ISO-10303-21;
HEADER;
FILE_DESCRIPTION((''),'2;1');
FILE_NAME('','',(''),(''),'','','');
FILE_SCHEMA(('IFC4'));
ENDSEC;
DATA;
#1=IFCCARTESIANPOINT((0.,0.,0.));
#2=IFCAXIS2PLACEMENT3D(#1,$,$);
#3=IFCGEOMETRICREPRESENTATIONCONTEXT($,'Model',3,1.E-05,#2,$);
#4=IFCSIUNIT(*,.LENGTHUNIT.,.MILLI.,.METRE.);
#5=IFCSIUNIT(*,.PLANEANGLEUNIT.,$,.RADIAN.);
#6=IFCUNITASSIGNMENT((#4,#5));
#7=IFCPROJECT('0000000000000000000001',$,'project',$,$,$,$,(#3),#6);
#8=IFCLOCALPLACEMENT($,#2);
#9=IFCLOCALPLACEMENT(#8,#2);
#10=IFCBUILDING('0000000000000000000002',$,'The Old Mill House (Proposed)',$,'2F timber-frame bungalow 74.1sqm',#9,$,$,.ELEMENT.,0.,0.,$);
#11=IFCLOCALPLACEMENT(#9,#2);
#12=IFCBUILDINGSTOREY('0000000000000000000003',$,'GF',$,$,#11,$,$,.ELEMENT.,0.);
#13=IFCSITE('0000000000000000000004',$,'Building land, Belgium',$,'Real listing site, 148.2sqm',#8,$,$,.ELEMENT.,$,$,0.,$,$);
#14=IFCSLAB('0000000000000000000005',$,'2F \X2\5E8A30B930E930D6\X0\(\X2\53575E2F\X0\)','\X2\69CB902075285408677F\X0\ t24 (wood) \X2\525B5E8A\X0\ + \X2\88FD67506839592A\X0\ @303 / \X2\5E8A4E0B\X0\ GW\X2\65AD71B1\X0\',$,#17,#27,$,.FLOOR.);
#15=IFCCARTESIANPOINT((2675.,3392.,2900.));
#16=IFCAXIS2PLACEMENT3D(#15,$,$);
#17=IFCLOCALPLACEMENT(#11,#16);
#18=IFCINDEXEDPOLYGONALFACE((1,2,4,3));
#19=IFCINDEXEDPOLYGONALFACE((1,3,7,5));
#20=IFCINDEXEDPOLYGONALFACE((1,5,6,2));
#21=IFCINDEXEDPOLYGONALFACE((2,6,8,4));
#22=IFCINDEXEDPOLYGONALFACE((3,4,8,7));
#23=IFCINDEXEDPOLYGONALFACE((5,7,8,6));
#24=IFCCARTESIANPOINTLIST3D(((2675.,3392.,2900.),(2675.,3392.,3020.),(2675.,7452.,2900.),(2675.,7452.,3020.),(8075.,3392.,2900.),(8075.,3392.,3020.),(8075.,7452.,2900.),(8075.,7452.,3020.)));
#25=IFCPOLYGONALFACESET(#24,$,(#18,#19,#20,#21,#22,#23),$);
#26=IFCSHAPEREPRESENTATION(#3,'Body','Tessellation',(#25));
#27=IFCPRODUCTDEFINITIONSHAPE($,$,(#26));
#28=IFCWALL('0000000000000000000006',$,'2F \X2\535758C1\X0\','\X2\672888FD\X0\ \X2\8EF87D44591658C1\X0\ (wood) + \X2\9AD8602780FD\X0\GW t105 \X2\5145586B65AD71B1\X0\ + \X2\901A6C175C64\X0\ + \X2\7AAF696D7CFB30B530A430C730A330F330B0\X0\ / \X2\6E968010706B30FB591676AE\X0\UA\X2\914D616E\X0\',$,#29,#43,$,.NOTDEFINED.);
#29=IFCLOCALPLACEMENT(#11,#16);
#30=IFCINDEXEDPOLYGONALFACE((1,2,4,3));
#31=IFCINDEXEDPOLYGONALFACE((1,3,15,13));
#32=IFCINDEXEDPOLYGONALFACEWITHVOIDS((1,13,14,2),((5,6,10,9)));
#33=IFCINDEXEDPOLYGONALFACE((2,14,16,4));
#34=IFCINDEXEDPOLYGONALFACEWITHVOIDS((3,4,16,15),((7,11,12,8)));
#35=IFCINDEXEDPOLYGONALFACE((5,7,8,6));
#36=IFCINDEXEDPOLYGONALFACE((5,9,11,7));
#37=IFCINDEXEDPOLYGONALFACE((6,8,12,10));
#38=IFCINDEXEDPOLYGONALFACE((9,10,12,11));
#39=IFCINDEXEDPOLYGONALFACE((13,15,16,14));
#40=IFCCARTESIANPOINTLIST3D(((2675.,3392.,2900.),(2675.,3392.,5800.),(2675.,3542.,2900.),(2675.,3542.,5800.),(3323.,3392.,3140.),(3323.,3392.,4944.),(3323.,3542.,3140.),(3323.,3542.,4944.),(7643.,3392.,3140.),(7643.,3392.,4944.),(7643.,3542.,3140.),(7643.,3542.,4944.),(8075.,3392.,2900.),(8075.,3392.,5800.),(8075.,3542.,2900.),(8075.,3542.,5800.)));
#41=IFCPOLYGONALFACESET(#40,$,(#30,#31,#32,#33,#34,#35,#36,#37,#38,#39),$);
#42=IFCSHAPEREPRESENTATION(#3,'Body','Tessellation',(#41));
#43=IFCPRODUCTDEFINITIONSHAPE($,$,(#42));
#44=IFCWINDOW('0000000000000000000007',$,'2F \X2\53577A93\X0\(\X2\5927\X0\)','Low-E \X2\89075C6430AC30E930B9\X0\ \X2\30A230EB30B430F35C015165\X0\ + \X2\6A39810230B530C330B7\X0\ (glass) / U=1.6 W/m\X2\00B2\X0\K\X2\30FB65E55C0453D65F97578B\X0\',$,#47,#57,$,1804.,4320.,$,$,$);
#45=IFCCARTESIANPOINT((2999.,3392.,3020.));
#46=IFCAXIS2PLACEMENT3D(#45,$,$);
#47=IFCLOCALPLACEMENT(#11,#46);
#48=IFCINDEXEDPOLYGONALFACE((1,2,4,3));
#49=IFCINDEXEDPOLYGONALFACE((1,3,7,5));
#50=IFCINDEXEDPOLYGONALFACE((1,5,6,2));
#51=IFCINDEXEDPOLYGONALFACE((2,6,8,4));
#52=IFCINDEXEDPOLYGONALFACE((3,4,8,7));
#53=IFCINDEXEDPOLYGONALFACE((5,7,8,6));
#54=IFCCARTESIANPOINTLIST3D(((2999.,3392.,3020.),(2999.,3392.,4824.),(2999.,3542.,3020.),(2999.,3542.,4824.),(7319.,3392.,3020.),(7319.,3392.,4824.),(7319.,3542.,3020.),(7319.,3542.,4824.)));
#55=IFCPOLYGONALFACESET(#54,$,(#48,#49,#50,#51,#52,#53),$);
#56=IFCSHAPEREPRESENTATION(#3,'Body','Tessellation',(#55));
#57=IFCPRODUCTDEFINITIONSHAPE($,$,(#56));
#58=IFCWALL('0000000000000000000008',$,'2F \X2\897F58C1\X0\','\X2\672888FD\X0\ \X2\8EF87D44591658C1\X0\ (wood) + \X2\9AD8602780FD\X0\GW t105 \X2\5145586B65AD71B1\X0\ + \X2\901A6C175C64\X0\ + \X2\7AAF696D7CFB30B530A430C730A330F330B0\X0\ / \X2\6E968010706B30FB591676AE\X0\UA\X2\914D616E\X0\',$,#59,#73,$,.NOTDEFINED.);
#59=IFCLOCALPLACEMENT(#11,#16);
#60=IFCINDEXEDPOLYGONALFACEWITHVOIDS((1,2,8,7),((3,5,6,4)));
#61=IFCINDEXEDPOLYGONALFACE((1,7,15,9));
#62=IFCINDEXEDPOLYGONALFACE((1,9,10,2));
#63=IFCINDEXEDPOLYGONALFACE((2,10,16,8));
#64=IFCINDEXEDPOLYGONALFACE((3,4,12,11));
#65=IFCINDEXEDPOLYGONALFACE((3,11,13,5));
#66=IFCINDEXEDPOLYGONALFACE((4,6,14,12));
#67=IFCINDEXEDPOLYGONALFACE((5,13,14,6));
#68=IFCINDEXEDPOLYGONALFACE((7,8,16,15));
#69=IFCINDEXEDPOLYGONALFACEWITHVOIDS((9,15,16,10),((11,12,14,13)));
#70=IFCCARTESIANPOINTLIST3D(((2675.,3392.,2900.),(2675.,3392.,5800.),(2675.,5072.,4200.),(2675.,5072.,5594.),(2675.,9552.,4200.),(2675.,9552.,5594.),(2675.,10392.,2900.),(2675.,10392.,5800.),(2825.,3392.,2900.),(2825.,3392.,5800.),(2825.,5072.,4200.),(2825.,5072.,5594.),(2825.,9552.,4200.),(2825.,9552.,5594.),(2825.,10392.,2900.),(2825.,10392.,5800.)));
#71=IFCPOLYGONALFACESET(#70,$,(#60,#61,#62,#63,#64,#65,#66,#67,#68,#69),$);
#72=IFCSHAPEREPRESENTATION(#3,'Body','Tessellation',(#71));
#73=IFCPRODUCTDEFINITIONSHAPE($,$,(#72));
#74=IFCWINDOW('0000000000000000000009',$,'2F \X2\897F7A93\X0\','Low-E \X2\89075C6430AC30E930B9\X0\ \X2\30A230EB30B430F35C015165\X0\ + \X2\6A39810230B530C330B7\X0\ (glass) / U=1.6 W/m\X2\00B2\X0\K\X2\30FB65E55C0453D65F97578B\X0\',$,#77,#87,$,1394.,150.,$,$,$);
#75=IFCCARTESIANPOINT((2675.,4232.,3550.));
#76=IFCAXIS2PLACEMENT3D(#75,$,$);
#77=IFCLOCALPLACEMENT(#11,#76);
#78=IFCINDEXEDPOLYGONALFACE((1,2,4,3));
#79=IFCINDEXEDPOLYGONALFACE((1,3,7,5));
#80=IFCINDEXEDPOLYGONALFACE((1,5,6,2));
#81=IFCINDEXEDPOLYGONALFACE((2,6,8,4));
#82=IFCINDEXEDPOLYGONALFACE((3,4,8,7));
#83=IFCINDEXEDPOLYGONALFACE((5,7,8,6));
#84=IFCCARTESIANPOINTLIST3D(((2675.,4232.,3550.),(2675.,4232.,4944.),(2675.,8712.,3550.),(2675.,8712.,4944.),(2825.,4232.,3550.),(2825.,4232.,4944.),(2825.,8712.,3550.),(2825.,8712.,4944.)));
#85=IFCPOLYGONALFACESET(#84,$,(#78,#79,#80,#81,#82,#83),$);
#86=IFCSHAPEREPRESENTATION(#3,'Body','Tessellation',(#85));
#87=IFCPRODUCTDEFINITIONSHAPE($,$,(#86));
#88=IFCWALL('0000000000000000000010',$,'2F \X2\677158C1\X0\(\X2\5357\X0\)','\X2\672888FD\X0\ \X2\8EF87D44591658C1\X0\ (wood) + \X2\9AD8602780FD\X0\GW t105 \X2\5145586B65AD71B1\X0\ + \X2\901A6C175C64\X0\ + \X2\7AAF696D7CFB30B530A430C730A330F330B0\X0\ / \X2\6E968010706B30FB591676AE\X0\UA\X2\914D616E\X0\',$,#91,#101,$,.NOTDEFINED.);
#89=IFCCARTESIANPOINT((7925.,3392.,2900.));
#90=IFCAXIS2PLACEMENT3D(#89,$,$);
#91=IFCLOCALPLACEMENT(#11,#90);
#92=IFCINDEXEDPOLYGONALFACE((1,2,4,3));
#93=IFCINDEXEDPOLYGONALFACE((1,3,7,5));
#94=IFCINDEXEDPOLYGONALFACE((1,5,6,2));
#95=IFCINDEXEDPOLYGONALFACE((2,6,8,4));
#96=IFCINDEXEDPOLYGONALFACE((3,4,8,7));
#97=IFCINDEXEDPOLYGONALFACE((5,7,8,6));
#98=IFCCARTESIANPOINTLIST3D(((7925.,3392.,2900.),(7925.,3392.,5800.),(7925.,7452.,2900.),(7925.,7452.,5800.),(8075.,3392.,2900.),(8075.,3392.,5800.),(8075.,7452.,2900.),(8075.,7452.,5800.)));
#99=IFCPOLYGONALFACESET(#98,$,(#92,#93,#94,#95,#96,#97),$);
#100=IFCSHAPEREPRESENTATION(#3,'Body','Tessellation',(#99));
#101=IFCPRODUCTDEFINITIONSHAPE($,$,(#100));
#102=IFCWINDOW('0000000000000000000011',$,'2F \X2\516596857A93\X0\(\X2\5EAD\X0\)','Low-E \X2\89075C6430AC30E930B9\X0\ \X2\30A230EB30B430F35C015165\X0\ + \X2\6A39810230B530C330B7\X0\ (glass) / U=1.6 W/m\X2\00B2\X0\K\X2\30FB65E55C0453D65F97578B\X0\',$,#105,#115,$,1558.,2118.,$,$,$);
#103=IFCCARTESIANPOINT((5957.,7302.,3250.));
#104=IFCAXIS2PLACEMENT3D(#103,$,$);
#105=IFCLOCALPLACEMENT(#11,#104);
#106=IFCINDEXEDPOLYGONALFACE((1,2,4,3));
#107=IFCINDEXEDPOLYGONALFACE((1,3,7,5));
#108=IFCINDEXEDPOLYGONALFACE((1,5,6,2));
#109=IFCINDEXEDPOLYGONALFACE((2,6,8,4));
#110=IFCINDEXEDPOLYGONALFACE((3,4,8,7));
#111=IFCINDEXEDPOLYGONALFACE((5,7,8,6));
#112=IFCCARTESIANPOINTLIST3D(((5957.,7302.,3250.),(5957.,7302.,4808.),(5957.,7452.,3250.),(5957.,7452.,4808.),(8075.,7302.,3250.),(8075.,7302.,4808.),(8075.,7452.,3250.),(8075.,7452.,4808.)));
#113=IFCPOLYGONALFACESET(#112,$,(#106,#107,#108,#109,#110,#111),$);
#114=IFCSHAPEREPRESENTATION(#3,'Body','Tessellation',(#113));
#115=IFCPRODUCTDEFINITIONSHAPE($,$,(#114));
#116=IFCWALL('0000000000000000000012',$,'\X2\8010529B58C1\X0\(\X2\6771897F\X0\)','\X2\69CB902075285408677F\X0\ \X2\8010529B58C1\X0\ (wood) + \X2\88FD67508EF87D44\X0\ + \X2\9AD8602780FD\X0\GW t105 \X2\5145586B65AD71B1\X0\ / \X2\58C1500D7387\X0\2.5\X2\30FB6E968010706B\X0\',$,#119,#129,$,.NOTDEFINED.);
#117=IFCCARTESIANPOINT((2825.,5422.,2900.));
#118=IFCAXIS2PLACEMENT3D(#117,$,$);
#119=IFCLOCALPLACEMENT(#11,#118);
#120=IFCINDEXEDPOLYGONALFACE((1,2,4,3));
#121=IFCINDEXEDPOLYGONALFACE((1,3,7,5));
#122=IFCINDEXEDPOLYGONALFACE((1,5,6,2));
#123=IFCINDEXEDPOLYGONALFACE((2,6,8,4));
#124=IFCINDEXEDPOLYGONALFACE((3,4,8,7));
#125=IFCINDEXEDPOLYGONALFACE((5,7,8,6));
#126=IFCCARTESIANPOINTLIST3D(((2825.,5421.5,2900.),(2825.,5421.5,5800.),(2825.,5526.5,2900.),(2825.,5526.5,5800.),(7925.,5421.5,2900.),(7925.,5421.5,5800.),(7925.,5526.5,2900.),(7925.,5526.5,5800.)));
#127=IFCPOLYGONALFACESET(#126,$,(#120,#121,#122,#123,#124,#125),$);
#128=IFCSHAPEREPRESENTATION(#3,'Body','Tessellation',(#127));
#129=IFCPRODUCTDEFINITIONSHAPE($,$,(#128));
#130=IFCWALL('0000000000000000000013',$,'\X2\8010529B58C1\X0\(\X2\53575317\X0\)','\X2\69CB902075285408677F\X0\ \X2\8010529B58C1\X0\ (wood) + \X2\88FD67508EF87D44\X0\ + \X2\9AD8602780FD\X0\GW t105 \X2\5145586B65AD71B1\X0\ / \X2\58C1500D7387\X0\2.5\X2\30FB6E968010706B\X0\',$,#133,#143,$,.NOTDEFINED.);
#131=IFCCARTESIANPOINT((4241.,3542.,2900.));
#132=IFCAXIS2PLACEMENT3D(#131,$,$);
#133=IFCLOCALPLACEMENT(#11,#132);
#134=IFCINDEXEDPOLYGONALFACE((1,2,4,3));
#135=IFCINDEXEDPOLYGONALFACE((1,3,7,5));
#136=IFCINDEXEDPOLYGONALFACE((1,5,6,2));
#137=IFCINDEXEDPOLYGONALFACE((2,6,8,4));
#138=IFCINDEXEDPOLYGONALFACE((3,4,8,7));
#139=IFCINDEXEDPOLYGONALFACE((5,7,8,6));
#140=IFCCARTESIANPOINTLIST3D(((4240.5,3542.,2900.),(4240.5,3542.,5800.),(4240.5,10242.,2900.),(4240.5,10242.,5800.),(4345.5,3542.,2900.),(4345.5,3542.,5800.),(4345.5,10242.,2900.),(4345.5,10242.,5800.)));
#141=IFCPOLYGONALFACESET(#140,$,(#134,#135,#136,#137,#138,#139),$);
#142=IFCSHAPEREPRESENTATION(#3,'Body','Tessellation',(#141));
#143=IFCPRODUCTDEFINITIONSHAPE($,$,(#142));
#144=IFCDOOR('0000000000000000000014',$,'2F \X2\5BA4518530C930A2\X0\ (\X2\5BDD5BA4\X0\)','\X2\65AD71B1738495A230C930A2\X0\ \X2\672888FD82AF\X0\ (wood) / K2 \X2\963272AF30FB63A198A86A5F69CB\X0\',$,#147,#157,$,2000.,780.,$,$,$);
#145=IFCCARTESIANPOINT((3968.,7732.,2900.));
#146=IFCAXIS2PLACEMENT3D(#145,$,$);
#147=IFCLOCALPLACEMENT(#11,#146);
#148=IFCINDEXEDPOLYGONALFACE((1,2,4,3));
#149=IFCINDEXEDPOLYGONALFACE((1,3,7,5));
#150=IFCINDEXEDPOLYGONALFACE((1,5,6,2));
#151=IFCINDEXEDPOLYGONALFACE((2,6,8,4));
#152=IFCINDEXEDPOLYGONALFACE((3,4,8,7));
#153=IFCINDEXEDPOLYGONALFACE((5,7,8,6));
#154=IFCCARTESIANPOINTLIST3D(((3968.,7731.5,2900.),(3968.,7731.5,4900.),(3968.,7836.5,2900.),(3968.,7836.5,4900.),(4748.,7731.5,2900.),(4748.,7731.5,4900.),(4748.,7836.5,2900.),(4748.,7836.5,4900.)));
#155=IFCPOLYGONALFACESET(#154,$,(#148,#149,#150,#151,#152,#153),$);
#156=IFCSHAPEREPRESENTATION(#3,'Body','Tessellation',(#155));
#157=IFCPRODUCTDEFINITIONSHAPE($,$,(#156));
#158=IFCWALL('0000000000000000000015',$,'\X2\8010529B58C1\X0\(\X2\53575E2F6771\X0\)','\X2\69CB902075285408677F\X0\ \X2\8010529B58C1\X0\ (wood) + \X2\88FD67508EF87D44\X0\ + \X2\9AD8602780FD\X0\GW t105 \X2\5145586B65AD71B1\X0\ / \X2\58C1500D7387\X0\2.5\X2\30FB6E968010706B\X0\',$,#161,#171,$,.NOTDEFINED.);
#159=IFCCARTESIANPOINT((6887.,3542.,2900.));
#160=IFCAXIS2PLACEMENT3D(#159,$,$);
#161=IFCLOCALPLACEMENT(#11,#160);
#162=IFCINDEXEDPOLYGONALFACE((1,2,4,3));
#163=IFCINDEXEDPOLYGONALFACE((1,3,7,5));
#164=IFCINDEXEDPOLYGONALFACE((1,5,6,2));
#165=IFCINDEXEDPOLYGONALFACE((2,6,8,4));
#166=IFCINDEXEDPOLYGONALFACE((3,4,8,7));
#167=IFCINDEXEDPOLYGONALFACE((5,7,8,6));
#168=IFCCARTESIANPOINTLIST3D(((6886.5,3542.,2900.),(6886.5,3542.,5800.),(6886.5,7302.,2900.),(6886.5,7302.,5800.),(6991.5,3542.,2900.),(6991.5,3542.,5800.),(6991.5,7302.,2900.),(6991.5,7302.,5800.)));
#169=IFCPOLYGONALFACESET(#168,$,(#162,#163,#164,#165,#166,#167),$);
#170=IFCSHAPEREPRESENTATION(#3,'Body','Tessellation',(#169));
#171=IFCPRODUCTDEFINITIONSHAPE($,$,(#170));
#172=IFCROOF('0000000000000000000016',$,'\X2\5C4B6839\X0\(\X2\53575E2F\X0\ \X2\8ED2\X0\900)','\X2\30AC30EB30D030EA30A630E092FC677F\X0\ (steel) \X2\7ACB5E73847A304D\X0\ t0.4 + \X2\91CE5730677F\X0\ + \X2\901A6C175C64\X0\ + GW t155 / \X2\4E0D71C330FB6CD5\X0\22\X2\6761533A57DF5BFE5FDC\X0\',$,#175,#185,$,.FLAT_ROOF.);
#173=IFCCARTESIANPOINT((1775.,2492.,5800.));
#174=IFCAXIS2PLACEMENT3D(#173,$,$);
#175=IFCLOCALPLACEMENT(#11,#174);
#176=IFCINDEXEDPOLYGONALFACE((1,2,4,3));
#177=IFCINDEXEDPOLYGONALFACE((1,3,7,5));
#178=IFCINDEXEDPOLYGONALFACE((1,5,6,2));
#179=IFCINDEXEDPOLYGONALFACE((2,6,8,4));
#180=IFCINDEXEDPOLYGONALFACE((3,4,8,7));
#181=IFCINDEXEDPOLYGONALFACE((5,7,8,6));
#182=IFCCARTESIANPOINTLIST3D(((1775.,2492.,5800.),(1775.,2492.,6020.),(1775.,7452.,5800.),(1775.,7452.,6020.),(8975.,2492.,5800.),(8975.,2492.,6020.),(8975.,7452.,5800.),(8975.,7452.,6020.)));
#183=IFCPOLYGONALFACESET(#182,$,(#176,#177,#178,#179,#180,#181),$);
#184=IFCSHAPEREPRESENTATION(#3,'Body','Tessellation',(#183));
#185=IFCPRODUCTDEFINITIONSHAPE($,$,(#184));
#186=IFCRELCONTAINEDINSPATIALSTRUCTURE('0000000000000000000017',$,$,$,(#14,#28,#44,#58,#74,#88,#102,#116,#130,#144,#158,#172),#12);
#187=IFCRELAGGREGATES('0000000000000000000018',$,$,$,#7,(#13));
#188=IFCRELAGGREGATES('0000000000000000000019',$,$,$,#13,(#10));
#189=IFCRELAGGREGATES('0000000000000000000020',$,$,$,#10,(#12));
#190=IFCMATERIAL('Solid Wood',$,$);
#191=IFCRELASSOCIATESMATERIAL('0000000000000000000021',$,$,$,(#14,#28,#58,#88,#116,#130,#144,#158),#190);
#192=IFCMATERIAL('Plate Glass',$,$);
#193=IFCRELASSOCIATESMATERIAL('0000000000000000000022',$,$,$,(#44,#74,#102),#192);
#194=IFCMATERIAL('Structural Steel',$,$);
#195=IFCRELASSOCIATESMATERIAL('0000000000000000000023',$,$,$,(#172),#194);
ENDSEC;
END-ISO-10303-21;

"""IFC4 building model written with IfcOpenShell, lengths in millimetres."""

from ifc_helpers import new_model, si_unit, frame, frame_2d, origin, place, context, project, spatial, rectangle, extrude, material, element, fill, save


model = new_model("IFC4")

# Units and contexts
model_context = context("Model", 3, precision=1e-05, world=origin())
ifc_project = project(units=[si_unit("LENGTHUNIT", "METRE", prefix="MILLI"), si_unit("PLANEANGLEUNIT", "RADIAN")], contexts=[model_context])

# Site, building, storey
site_placement = place(None, origin())
site = spatial("IfcSite", under=ifc_project, at=site_placement, Name="Building land, Belgium", ObjectType="Real listing site, 148.2sqm", CompositionType="ELEMENT", RefElevation=0.0)
building_placement = place(site_placement, origin())
building = spatial("IfcBuilding", under=site, at=building_placement, Name="The Old Mill House (Proposed)", ObjectType="2F timber-frame bungalow 74.1sqm", CompositionType="ELEMENT", ElevationOfRefHeight=0.0, ElevationOfTerrain=0.0)
storey_placement = place(building_placement, origin())
storey = spatial("IfcBuildingStorey", under=building, at=storey_placement, Name="GF", CompositionType="ELEMENT", Elevation=0.0)

# Slab
ifc_material_1 = material(Name="Solid Wood")
slab_placement = place(storey_placement, frame((2675.0, 3392.0, 2900.0)))
element("IfcSlab", 1, at=slab_placement, inside=storey, material=ifc_material_1, Name="2F 床スラブ(南帯)", Description="構造用合板 t24 (wood) 剛床 + 製材根太 @303 / 床下 GW断熱", PredefinedType="FLOOR", context=model_context, shape_type="SweptSolid", body=[
    extrude(rectangle(XDim=5400.0, YDim=4060.0, at=frame_2d((2700.0, 2030.0))), frame((2675.0, 3392.0, 2900.0)), (0.0, 0.0, 1.0), 120.0),
])

# Walls, openings, windows
wall_1_placement = place(storey_placement, frame((2675.0, 3392.0, 2900.0)))
wall_1 = element("IfcWall", 2, at=wall_1_placement, inside=storey, material=ifc_material_1, Name="2F 南壁", Description="木製 軸組外壁 (wood) + 高性能GW t105 充填断熱 + 通気層 + 窯業系サイディング / 準耐火・外皮UA配慮", PredefinedType="NOTDEFINED", context=model_context, shape_type="SweptSolid", body=[
    extrude(rectangle(XDim=5400.0, YDim=150.0, at=frame_2d((2700.0, 75.0))), frame((2675.0, 3392.0, 2900.0)), (0.0, 0.0, 1.0), 2900.0),
])
opening_1_placement = place(storey_placement, frame((2999.0, 3392.0, 3020.0)))
opening_1 = element("IfcOpeningElement", 3, at=opening_1_placement, cuts=wall_1, PredefinedType="NOTDEFINED", context=model_context, shape_type="SweptSolid", body=[
    extrude(rectangle(XDim=4320.0, YDim=150.0, at=frame_2d((2160.0, 75.0))), frame((2999.0, 3392.0, 3020.0)), (0.0, 0.0, 1.0), 1804.0),
])
ifc_material_2 = material(Name="Plate Glass")
window_1_placement = place(storey_placement, frame((2999.0, 3392.0, 3020.0)))
window_1 = element("IfcWindow", 4, at=window_1_placement, inside=storey, material=ifc_material_2, Name="2F 南窓(大)", Description="Low-E 複層ガラス アルゴン封入 + 樹脂サッシ (glass) / U=1.6 W/m²K・日射取得型", OverallHeight=1804.0, OverallWidth=4320.0, context=model_context, shape_type="SweptSolid", body=[
    extrude(rectangle(XDim=4320.0, YDim=150.0, at=frame_2d((2160.0, 75.0))), frame((2999.0, 3392.0, 3020.0)), (0.0, 0.0, 1.0), 1804.0),
])
fill(opening_1, window_1)
wall_2_placement = place(storey_placement, frame((2675.0, 3392.0, 2900.0)))
wall_2 = element("IfcWall", 5, at=wall_2_placement, inside=storey, material=ifc_material_1, Name="2F 西壁", Description="木製 軸組外壁 (wood) + 高性能GW t105 充填断熱 + 通気層 + 窯業系サイディング / 準耐火・外皮UA配慮", PredefinedType="NOTDEFINED", context=model_context, shape_type="SweptSolid", body=[
    extrude(rectangle(XDim=150.0, YDim=7000.0, at=frame_2d((75.0, 3500.0))), frame((2675.0, 3392.0, 2900.0)), (0.0, 0.0, 1.0), 2900.0),
])
opening_2_placement = place(storey_placement, frame((2675.0, 4232.0, 3550.0)))
opening_2 = element("IfcOpeningElement", 6, at=opening_2_placement, cuts=wall_2, PredefinedType="NOTDEFINED", context=model_context, shape_type="SweptSolid", body=[
    extrude(rectangle(XDim=150.0, YDim=4480.0, at=frame_2d((75.0, 2240.0))), frame((2675.0, 4232.0, 3550.0)), (0.0, 0.0, 1.0), 1394.0),
])
window_2_placement = place(storey_placement, frame((2675.0, 4232.0, 3550.0)))
window_2 = element("IfcWindow", 7, at=window_2_placement, inside=storey, material=ifc_material_2, Name="2F 西窓", Description="Low-E 複層ガラス アルゴン封入 + 樹脂サッシ (glass) / U=1.6 W/m²K・日射取得型", OverallHeight=1394.0, OverallWidth=150.0, context=model_context, shape_type="SweptSolid", body=[
    extrude(rectangle(XDim=150.0, YDim=4480.0, at=frame_2d((75.0, 2240.0))), frame((2675.0, 4232.0, 3550.0)), (0.0, 0.0, 1.0), 1394.0),
])
fill(opening_2, window_2)
wall_3_placement = place(storey_placement, frame((7925.0, 3392.0, 2900.0)))
wall_3 = element("IfcWall", 8, at=wall_3_placement, inside=storey, material=ifc_material_1, Name="2F 東壁(南)", Description="木製 軸組外壁 (wood) + 高性能GW t105 充填断熱 + 通気層 + 窯業系サイディング / 準耐火・外皮UA配慮", PredefinedType="NOTDEFINED", context=model_context, shape_type="SweptSolid", body=[
    extrude(rectangle(XDim=150.0, YDim=4060.0, at=frame_2d((75.0, 2030.0))), frame((7925.0, 3392.0, 2900.0)), (0.0, 0.0, 1.0), 2900.0),
])
opening_3_placement = place(storey_placement, frame((5957.0, 7302.0, 3250.0)))
opening_3 = element("IfcOpeningElement", 9, at=opening_3_placement, cuts=wall_3, PredefinedType="NOTDEFINED", context=model_context, shape_type="SweptSolid", body=[
    extrude(rectangle(XDim=2118.0, YDim=150.0, at=frame_2d((1059.0, 75.0))), frame((5957.0, 7302.0, 3250.0)), (0.0, 0.0, 1.0), 1558.0),
])
window_3_placement = place(storey_placement, frame((5957.0, 7302.0, 3250.0)))
window_3 = element("IfcWindow", 10, at=window_3_placement, inside=storey, material=ifc_material_2, Name="2F 入隅窓(庭)", Description="Low-E 複層ガラス アルゴン封入 + 樹脂サッシ (glass) / U=1.6 W/m²K・日射取得型", OverallHeight=1558.0, OverallWidth=2118.0, context=model_context, shape_type="SweptSolid", body=[
    extrude(rectangle(XDim=2118.0, YDim=150.0, at=frame_2d((1059.0, 75.0))), frame((5957.0, 7302.0, 3250.0)), (0.0, 0.0, 1.0), 1558.0),
])
fill(opening_3, window_3)

# Wall
wall_4_placement = place(storey_placement, frame((2825.0, 5422.0, 2900.0)))
element("IfcWall", 11, at=wall_4_placement, inside=storey, material=ifc_material_1, Name="耐力壁(東西)", Description="構造用合板 耐力壁 (wood) + 製材軸組 + 高性能GW t105 充填断熱 / 壁倍率2.5・準耐火", PredefinedType="NOTDEFINED", context=model_context, shape_type="SweptSolid", body=[
    extrude(rectangle(XDim=5100.0, YDim=105.0, at=frame_2d((2550.0, 52.0))), frame((2825.0, 5422.0, 2900.0)), (0.0, 0.0, 1.0), 2900.0),
])

# Wall, opening, door
wall_5_placement = place(storey_placement, frame((4241.0, 3542.0, 2900.0)))
wall_5 = element("IfcWall", 12, at=wall_5_placement, inside=storey, material=ifc_material_1, Name="耐力壁(南北)", Description="構造用合板 耐力壁 (wood) + 製材軸組 + 高性能GW t105 充填断熱 / 壁倍率2.5・準耐火", PredefinedType="NOTDEFINED", context=model_context, shape_type="SweptSolid", body=[
    extrude(rectangle(XDim=105.0, YDim=6700.0, at=frame_2d((52.0, 3350.0))), frame((4241.0, 3542.0, 2900.0)), (0.0, 0.0, 1.0), 2900.0),
])
opening_4_placement = place(storey_placement, frame((3968.0, 7732.0, 2900.0)))
opening_4 = element("IfcOpeningElement", 13, at=opening_4_placement, cuts=wall_5, PredefinedType="NOTDEFINED", context=model_context, shape_type="SweptSolid", body=[
    extrude(rectangle(XDim=780.0, YDim=105.0, at=frame_2d((390.0, 52.0))), frame((3968.0, 7732.0, 2900.0)), (0.0, 0.0, 1.0), 2000.0),
])
door_placement = place(storey_placement, frame((3968.0, 7732.0, 2900.0)))
door = element("IfcDoor", 14, at=door_placement, inside=storey, material=ifc_material_1, Name="2F 室内ドア (寝室)", Description="断熱玄関ドア 木製芯 (wood) / K2 防犯・採風機構", OverallHeight=2000.0, OverallWidth=780.0, context=model_context, shape_type="SweptSolid", body=[
    extrude(rectangle(XDim=780.0, YDim=105.0, at=frame_2d((390.0, 52.0))), frame((3968.0, 7732.0, 2900.0)), (0.0, 0.0, 1.0), 2000.0),
])
fill(opening_4, door)

# Wall
wall_6_placement = place(storey_placement, frame((6887.0, 3542.0, 2900.0)))
element("IfcWall", 15, at=wall_6_placement, inside=storey, material=ifc_material_1, Name="耐力壁(南帯東)", Description="構造用合板 耐力壁 (wood) + 製材軸組 + 高性能GW t105 充填断熱 / 壁倍率2.5・準耐火", PredefinedType="NOTDEFINED", context=model_context, shape_type="SweptSolid", body=[
    extrude(rectangle(XDim=105.0, YDim=3760.0, at=frame_2d((52.0, 1880.0))), frame((6887.0, 3542.0, 2900.0)), (0.0, 0.0, 1.0), 2900.0),
])

# Roof
ifc_material_3 = material(Name="Structural Steel")
for number, where, name in (
    (16, (1775.0, 2492.0, 5800.0), "屋根(南帯 軒900)"),
):
    element("IfcRoof", number, at=place(storey_placement, frame(where)), inside=storey, material=ifc_material_3, Name=name, Description="ガルバリウム鋼板 (steel) 立平葺き t0.4 + 野地板 + 通気層 + GW t155 / 不燃・法22条区域対応", PredefinedType="FLAT_ROOF", context=model_context, shape_type="SweptSolid", body=[
        extrude(rectangle(XDim=7200.0, YDim=4960.0, at=frame_2d((3600.0, 2480.0))), frame((1775.0, 2492.0, 5800.0)), (0.0, 0.0, 1.0), 220.0),
    ])

save(model, "model.ifc")
